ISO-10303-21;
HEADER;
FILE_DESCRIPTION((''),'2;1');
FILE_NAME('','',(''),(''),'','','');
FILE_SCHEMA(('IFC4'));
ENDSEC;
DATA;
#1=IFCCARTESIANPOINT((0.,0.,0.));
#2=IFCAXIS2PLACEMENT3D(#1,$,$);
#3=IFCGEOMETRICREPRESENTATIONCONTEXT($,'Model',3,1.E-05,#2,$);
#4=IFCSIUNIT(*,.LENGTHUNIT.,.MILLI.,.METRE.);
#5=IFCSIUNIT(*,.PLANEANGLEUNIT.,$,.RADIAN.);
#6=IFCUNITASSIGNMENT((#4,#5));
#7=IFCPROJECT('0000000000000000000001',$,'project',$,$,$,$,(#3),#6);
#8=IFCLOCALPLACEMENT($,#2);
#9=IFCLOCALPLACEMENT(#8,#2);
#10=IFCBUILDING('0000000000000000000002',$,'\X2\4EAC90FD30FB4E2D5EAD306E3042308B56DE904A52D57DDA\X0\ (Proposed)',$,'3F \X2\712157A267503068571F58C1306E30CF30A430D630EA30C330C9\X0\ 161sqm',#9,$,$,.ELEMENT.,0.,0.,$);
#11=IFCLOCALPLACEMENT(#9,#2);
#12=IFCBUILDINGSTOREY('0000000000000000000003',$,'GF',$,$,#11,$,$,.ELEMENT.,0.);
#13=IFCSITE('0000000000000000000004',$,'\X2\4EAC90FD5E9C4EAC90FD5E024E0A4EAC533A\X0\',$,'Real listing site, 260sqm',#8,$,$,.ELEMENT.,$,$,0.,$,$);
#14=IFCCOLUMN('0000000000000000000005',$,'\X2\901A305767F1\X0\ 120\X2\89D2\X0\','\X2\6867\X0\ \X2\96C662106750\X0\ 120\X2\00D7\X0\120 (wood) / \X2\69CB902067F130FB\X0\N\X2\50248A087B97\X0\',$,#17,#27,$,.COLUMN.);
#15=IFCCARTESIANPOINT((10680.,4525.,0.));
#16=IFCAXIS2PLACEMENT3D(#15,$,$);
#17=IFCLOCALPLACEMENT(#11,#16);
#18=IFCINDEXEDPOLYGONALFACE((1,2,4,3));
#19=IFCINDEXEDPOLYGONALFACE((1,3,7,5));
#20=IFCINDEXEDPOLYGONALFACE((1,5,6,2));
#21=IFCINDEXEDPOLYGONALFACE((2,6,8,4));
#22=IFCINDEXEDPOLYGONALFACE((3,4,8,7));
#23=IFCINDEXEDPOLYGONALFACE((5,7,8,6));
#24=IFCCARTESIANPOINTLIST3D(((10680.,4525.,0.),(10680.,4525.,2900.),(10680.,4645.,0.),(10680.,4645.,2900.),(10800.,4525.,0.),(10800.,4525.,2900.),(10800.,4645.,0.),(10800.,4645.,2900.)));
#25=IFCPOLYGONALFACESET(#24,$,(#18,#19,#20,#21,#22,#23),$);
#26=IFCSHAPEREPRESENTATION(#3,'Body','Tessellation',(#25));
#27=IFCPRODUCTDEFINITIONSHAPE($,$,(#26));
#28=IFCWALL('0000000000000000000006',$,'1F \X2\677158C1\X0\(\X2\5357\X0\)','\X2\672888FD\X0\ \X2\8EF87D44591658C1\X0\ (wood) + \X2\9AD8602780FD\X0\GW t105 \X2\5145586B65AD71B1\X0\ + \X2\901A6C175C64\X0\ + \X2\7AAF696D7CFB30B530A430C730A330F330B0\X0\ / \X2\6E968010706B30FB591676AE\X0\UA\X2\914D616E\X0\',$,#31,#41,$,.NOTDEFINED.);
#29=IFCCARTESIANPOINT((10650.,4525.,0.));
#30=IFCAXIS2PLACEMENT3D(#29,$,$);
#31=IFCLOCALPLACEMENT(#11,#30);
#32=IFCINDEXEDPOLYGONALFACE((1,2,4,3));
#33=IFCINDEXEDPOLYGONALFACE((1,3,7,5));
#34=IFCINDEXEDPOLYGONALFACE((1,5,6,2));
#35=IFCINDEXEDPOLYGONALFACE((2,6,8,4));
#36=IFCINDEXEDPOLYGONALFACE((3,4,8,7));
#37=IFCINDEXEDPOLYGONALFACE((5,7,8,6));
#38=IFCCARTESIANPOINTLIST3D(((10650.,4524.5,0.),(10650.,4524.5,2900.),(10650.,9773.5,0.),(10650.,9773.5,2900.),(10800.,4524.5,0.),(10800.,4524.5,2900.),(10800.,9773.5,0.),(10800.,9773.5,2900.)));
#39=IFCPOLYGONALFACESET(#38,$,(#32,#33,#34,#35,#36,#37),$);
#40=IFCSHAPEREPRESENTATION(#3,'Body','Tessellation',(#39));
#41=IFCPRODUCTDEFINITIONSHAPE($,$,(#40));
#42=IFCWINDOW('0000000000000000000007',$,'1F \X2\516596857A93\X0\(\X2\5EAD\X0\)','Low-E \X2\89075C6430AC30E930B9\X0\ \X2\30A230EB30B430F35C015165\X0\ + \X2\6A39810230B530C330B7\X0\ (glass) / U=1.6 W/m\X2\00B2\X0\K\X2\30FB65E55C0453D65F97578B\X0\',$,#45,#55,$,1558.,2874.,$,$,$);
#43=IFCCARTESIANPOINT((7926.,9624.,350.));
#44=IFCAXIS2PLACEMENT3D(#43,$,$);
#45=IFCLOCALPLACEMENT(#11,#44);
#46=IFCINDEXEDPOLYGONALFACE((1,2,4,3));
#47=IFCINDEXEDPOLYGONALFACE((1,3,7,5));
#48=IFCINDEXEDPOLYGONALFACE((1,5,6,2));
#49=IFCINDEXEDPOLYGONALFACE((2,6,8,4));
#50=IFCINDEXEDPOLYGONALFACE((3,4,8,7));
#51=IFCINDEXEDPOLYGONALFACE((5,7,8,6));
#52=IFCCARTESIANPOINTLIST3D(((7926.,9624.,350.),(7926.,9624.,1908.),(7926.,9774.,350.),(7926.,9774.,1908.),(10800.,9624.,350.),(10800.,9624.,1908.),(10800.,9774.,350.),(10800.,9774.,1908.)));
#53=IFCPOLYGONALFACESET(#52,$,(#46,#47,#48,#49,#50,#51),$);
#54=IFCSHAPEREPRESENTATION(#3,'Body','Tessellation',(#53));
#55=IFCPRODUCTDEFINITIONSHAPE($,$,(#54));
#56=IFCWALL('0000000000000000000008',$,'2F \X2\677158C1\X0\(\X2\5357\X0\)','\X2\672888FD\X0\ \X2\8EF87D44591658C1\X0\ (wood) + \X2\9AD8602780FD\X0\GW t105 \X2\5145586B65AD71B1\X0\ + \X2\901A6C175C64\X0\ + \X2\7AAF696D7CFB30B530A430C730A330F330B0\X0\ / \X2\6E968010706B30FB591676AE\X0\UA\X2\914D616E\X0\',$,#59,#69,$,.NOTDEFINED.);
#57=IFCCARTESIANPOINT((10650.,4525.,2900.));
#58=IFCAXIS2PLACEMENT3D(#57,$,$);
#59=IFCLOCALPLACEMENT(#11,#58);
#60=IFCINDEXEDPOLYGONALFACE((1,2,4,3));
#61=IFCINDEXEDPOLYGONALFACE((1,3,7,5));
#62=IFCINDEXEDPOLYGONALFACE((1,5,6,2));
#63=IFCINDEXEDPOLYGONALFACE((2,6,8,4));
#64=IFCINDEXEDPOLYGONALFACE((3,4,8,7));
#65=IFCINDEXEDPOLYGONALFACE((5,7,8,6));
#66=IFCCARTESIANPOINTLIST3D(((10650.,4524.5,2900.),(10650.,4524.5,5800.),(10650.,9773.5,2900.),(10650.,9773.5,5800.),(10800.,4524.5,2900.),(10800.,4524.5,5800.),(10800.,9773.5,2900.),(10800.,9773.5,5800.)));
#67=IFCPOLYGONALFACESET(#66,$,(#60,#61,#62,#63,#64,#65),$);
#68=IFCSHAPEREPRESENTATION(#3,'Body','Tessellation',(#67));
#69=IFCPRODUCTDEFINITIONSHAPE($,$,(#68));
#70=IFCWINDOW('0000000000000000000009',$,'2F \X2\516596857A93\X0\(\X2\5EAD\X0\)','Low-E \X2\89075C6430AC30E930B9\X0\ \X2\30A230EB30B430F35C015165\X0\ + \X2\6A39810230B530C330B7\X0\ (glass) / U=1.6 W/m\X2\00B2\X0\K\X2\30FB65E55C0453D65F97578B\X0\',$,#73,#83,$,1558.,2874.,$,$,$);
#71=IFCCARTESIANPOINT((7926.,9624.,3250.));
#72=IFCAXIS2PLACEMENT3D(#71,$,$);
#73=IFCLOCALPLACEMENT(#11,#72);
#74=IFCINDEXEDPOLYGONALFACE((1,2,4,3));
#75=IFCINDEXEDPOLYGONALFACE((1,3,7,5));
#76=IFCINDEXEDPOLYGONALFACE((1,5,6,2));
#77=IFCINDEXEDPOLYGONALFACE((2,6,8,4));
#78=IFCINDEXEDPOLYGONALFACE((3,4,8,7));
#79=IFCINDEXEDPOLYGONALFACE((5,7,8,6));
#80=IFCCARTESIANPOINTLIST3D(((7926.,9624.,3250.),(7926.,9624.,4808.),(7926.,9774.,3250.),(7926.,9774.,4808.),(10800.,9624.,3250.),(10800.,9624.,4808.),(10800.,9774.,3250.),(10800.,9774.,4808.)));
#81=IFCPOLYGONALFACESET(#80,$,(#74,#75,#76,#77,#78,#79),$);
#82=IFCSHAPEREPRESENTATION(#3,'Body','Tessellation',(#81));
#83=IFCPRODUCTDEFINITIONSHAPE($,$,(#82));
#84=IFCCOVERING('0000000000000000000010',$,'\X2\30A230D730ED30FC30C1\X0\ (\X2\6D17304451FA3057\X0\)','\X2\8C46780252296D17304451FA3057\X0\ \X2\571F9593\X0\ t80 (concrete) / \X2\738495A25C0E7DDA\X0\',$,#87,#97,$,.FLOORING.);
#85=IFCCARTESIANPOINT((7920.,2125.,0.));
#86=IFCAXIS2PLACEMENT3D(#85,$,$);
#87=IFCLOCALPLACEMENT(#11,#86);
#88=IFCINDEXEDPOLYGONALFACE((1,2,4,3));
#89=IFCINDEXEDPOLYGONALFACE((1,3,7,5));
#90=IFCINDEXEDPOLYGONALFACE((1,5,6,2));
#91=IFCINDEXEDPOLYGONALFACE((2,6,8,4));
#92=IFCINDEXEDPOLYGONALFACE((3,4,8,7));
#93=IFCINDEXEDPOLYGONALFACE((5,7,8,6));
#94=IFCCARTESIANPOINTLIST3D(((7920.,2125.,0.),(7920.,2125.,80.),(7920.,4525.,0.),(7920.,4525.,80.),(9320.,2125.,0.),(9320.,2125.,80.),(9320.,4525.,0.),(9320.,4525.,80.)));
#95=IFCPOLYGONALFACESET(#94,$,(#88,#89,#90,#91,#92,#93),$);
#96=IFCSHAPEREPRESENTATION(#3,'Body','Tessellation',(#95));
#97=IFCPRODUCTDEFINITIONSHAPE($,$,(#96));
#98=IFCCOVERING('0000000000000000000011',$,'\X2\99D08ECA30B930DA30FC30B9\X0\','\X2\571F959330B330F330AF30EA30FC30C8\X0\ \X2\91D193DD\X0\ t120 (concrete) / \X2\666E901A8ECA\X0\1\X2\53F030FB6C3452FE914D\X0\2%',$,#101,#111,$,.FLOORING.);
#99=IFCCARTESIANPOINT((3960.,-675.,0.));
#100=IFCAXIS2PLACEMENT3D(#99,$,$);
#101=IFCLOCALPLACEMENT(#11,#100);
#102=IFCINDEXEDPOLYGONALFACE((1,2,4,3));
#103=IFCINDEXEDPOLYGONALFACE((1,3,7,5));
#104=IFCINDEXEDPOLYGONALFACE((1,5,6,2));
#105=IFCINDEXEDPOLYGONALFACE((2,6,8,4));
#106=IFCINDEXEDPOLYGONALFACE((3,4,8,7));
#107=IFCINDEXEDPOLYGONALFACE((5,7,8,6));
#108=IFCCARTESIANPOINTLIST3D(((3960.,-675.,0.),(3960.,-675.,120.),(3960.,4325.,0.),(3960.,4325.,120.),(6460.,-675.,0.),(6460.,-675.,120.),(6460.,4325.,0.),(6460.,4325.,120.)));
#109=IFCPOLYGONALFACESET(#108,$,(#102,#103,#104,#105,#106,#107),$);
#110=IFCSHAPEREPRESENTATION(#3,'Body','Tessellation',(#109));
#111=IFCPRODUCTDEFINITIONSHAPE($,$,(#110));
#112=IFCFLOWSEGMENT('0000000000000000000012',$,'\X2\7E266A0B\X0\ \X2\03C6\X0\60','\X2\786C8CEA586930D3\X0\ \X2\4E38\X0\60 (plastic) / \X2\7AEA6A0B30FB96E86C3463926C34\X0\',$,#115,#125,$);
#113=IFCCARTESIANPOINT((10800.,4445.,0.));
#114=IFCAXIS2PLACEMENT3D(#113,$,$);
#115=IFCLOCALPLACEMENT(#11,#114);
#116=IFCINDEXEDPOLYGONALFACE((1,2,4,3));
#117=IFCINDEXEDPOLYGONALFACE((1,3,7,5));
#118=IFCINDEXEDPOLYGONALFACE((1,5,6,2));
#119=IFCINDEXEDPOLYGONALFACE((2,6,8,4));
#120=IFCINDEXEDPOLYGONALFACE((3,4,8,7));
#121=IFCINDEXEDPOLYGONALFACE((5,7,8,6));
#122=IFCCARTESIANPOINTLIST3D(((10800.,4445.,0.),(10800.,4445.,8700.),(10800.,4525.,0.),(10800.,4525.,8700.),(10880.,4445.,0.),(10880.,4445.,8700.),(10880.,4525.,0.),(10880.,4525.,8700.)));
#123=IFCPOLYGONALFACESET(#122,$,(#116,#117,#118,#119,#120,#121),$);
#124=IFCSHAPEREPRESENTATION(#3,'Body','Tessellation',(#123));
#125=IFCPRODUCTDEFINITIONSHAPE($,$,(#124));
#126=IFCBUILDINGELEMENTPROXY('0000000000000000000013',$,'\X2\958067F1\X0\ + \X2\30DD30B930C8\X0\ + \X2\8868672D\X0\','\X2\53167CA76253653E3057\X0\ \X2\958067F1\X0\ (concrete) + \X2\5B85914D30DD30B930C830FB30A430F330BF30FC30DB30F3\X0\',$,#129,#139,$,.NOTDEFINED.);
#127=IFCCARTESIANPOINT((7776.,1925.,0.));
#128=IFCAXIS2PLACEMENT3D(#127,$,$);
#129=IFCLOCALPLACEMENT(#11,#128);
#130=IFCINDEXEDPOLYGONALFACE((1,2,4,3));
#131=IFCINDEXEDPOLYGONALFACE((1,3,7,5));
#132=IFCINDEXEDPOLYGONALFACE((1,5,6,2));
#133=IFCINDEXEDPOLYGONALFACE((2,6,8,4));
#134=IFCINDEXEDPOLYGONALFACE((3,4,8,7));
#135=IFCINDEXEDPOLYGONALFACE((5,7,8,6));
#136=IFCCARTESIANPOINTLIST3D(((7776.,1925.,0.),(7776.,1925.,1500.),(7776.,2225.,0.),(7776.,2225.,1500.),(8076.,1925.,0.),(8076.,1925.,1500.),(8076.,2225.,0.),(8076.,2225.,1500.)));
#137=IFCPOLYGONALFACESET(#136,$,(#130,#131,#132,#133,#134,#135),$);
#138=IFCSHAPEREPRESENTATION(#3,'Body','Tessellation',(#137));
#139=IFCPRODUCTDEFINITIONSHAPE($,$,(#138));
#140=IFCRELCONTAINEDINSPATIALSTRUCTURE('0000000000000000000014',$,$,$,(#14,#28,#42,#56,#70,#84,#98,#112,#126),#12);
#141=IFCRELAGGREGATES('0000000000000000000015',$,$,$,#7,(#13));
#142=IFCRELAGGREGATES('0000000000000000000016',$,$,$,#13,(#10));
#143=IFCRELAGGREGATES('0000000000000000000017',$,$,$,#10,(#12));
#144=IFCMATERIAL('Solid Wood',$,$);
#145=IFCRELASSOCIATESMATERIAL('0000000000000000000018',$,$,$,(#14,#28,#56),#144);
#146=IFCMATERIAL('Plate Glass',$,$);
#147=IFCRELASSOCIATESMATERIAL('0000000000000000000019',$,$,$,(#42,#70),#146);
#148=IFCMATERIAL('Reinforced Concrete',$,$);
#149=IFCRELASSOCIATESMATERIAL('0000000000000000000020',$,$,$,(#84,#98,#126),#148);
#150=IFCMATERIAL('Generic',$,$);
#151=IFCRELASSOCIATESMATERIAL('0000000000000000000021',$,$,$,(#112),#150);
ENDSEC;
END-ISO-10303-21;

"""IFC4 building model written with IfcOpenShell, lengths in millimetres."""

from ifc_helpers import new_model, si_unit, frame, frame_2d, origin, place, context, project, spatial, rectangle, extrude, material, element, fill, save


model = new_model("IFC4")

# Units and contexts
model_context = context("Model", 3, precision=1e-05, world=origin())
ifc_project = project(units=[si_unit("LENGTHUNIT", "METRE", prefix="MILLI"), si_unit("PLANEANGLEUNIT", "RADIAN")], contexts=[model_context])

# Site, building, storey
site_placement = place(None, origin())
site = spatial("IfcSite", under=ifc_project, at=site_placement, Name="京都府京都市上京区", ObjectType="Real listing site, 260sqm", CompositionType="ELEMENT", RefElevation=0.0)
building_placement = place(site_placement, origin())
building = spatial("IfcBuilding", under=site, at=building_placement, Name="京都・中庭のある回遊動線 (Proposed)", ObjectType="3F 無垢材と土壁のハイブリッド 161sqm", CompositionType="ELEMENT", ElevationOfRefHeight=0.0, ElevationOfTerrain=0.0)
storey_placement = place(building_placement, origin())
storey = spatial("IfcBuildingStorey", under=building, at=storey_placement, Name="GF", CompositionType="ELEMENT", Elevation=0.0)

# Column
ifc_material_1 = material(Name="Solid Wood")
column_1_placement = place(storey_placement, frame((10680.0, 4525.0, 0.0)))
element("IfcColumn", 1, at=column_1_placement, inside=storey, material=ifc_material_1, Name="通し柱 120角", Description="桧 集成材 120×120 (wood) / 構造柱・N値計算", PredefinedType="COLUMN", context=model_context, shape_type="SweptSolid", body=[
    extrude(rectangle(XDim=120.0, YDim=120.0, at=frame_2d((60.0, 60.0))), frame((10680.0, 4525.0, 0.0)), (0.0, 0.0, 1.0), 2900.0),
])

# Wall, opening, window
wall_1_placement = place(storey_placement, frame((10650.0, 4525.0, 0.0)))
wall_1 = element("IfcWall", 2, at=wall_1_placement, inside=storey, material=ifc_material_1, Name="1F 東壁(南)", Description="木製 軸組外壁 (wood) + 高性能GW t105 充填断熱 + 通気層 + 窯業系サイディング / 準耐火・外皮UA配慮", PredefinedType="NOTDEFINED", context=model_context, shape_type="SweptSolid", body=[
    extrude(rectangle(XDim=150.0, YDim=5249.0, at=frame_2d((75.0, 2624.0))), frame((10650.0, 4525.0, 0.0)), (0.0, 0.0, 1.0), 2900.0),
])
opening_1_placement = place(storey_placement, frame((7926.0, 9624.0, 350.0)))
opening_1 = element("IfcOpeningElement", 3, at=opening_1_placement, cuts=wall_1, PredefinedType="NOTDEFINED", context=model_context, shape_type="SweptSolid", body=[
    extrude(rectangle(XDim=2874.0, YDim=150.0, at=frame_2d((1437.0, 75.0))), frame((7926.0, 9624.0, 350.0)), (0.0, 0.0, 1.0), 1558.0),
])
ifc_material_2 = material(Name="Plate Glass")
window_1_placement = place(storey_placement, frame((7926.0, 9624.0, 350.0)))
window_1 = element("IfcWindow", 4, at=window_1_placement, inside=storey, material=ifc_material_2, Name="1F 入隅窓(庭)", Description="Low-E 複層ガラス アルゴン封入 + 樹脂サッシ (glass) / U=1.6 W/m²K・日射取得型", OverallHeight=1558.0, OverallWidth=2874.0, context=model_context, shape_type="SweptSolid", body=[
    extrude(rectangle(XDim=2874.0, YDim=150.0, at=frame_2d((1437.0, 75.0))), frame((7926.0, 9624.0, 350.0)), (0.0, 0.0, 1.0), 1558.0),
])
fill(opening_1, window_1)

# Wall, opening, window
wall_2_placement = place(storey_placement, frame((10650.0, 4525.0, 2900.0)))
wall_2 = element("IfcWall", 5, at=wall_2_placement, inside=storey, material=ifc_material_1, Name="2F 東壁(南)", Description="木製 軸組外壁 (wood) + 高性能GW t105 充填断熱 + 通気層 + 窯業系サイディング / 準耐火・外皮UA配慮", PredefinedType="NOTDEFINED", context=model_context, shape_type="SweptSolid", body=[
    extrude(rectangle(XDim=150.0, YDim=5249.0, at=frame_2d((75.0, 2624.0))), frame((10650.0, 4525.0, 2900.0)), (0.0, 0.0, 1.0), 2900.0),
])
opening_2_placement = place(storey_placement, frame((7926.0, 9624.0, 3250.0)))
opening_2 = element("IfcOpeningElement", 6, at=opening_2_placement, cuts=wall_2, PredefinedType="NOTDEFINED", context=model_context, shape_type="SweptSolid", body=[
    extrude(rectangle(XDim=2874.0, YDim=150.0, at=frame_2d((1437.0, 75.0))), frame((7926.0, 9624.0, 3250.0)), (0.0, 0.0, 1.0), 1558.0),
])
window_2_placement = place(storey_placement, frame((7926.0, 9624.0, 3250.0)))
window_2 = element("IfcWindow", 7, at=window_2_placement, inside=storey, material=ifc_material_2, Name="2F 入隅窓(庭)", Description="Low-E 複層ガラス アルゴン封入 + 樹脂サッシ (glass) / U=1.6 W/m²K・日射取得型", OverallHeight=1558.0, OverallWidth=2874.0, context=model_context, shape_type="SweptSolid", body=[
    extrude(rectangle(XDim=2874.0, YDim=150.0, at=frame_2d((1437.0, 75.0))), frame((7926.0, 9624.0, 3250.0)), (0.0, 0.0, 1.0), 1558.0),
])
fill(opening_2, window_2)

# Coverings
ifc_material_3 = material(Name="Reinforced Concrete")
covering_1_placement = place(storey_placement, frame((7920.0, 2125.0, 0.0)))
element("IfcCovering", 8, at=covering_1_placement, inside=storey, material=ifc_material_3, Name="アプローチ (洗い出し)", Description="豆砂利洗い出し 土間 t80 (concrete) / 玄関導線", PredefinedType="FLOORING", context=model_context, shape_type="SweptSolid", body=[
    extrude(rectangle(XDim=1400.0, YDim=2400.0, at=frame_2d((700.0, 1200.0))), frame((7920.0, 2125.0, 0.0)), (0.0, 0.0, 1.0), 80.0),
])
covering_2_placement = place(storey_placement, frame((3960.0, -675.0, 0.0)))
element("IfcCovering", 9, at=covering_2_placement, inside=storey, material=ifc_material_3, Name="駐車スペース", Description="土間コンクリート 金鏝 t120 (concrete) / 普通車1台・水勾配2%", PredefinedType="FLOORING", context=model_context, shape_type="SweptSolid", body=[
    extrude(rectangle(XDim=2500.0, YDim=5000.0, at=frame_2d((1250.0, 2500.0))), frame((3960.0, -675.0, 0.0)), (0.0, 0.0, 1.0), 120.0),
])

# Flow segment
ifc_material_4 = material(Name="Generic")
flow_segment_placement = place(storey_placement, frame((10800.0, 4445.0, 0.0)))
element("IfcFlowSegment", 10, at=flow_segment_placement, inside=storey, material=ifc_material_4, Name="縦樋 φ60", Description="硬質塩ビ 丸60 (plastic) / 竪樋・雨水排水", context=model_context, shape_type="SweptSolid", body=[
    extrude(rectangle(XDim=80.0, YDim=80.0, at=frame_2d((40.0, 40.0))), frame((10800.0, 4445.0, 0.0)), (0.0, 0.0, 1.0), 8700.0),
])

# Building element proxy
proxy_placement = place(storey_placement, frame((7776.0, 1925.0, 0.0)))
element("IfcBuildingElementProxy", 11, at=proxy_placement, inside=storey, material=ifc_material_3, Name="門柱 + ポスト + 表札", Description="化粧打放し 門柱 (concrete) + 宅配ポスト・インターホン", PredefinedType="NOTDEFINED", context=model_context, shape_type="SweptSolid", body=[
    extrude(rectangle(XDim=300.0, YDim=300.0, at=frame_2d((150.0, 150.0))), frame((7776.0, 1925.0, 0.0)), (0.0, 0.0, 1.0), 1500.0),
])

save(model, "model.ifc")
